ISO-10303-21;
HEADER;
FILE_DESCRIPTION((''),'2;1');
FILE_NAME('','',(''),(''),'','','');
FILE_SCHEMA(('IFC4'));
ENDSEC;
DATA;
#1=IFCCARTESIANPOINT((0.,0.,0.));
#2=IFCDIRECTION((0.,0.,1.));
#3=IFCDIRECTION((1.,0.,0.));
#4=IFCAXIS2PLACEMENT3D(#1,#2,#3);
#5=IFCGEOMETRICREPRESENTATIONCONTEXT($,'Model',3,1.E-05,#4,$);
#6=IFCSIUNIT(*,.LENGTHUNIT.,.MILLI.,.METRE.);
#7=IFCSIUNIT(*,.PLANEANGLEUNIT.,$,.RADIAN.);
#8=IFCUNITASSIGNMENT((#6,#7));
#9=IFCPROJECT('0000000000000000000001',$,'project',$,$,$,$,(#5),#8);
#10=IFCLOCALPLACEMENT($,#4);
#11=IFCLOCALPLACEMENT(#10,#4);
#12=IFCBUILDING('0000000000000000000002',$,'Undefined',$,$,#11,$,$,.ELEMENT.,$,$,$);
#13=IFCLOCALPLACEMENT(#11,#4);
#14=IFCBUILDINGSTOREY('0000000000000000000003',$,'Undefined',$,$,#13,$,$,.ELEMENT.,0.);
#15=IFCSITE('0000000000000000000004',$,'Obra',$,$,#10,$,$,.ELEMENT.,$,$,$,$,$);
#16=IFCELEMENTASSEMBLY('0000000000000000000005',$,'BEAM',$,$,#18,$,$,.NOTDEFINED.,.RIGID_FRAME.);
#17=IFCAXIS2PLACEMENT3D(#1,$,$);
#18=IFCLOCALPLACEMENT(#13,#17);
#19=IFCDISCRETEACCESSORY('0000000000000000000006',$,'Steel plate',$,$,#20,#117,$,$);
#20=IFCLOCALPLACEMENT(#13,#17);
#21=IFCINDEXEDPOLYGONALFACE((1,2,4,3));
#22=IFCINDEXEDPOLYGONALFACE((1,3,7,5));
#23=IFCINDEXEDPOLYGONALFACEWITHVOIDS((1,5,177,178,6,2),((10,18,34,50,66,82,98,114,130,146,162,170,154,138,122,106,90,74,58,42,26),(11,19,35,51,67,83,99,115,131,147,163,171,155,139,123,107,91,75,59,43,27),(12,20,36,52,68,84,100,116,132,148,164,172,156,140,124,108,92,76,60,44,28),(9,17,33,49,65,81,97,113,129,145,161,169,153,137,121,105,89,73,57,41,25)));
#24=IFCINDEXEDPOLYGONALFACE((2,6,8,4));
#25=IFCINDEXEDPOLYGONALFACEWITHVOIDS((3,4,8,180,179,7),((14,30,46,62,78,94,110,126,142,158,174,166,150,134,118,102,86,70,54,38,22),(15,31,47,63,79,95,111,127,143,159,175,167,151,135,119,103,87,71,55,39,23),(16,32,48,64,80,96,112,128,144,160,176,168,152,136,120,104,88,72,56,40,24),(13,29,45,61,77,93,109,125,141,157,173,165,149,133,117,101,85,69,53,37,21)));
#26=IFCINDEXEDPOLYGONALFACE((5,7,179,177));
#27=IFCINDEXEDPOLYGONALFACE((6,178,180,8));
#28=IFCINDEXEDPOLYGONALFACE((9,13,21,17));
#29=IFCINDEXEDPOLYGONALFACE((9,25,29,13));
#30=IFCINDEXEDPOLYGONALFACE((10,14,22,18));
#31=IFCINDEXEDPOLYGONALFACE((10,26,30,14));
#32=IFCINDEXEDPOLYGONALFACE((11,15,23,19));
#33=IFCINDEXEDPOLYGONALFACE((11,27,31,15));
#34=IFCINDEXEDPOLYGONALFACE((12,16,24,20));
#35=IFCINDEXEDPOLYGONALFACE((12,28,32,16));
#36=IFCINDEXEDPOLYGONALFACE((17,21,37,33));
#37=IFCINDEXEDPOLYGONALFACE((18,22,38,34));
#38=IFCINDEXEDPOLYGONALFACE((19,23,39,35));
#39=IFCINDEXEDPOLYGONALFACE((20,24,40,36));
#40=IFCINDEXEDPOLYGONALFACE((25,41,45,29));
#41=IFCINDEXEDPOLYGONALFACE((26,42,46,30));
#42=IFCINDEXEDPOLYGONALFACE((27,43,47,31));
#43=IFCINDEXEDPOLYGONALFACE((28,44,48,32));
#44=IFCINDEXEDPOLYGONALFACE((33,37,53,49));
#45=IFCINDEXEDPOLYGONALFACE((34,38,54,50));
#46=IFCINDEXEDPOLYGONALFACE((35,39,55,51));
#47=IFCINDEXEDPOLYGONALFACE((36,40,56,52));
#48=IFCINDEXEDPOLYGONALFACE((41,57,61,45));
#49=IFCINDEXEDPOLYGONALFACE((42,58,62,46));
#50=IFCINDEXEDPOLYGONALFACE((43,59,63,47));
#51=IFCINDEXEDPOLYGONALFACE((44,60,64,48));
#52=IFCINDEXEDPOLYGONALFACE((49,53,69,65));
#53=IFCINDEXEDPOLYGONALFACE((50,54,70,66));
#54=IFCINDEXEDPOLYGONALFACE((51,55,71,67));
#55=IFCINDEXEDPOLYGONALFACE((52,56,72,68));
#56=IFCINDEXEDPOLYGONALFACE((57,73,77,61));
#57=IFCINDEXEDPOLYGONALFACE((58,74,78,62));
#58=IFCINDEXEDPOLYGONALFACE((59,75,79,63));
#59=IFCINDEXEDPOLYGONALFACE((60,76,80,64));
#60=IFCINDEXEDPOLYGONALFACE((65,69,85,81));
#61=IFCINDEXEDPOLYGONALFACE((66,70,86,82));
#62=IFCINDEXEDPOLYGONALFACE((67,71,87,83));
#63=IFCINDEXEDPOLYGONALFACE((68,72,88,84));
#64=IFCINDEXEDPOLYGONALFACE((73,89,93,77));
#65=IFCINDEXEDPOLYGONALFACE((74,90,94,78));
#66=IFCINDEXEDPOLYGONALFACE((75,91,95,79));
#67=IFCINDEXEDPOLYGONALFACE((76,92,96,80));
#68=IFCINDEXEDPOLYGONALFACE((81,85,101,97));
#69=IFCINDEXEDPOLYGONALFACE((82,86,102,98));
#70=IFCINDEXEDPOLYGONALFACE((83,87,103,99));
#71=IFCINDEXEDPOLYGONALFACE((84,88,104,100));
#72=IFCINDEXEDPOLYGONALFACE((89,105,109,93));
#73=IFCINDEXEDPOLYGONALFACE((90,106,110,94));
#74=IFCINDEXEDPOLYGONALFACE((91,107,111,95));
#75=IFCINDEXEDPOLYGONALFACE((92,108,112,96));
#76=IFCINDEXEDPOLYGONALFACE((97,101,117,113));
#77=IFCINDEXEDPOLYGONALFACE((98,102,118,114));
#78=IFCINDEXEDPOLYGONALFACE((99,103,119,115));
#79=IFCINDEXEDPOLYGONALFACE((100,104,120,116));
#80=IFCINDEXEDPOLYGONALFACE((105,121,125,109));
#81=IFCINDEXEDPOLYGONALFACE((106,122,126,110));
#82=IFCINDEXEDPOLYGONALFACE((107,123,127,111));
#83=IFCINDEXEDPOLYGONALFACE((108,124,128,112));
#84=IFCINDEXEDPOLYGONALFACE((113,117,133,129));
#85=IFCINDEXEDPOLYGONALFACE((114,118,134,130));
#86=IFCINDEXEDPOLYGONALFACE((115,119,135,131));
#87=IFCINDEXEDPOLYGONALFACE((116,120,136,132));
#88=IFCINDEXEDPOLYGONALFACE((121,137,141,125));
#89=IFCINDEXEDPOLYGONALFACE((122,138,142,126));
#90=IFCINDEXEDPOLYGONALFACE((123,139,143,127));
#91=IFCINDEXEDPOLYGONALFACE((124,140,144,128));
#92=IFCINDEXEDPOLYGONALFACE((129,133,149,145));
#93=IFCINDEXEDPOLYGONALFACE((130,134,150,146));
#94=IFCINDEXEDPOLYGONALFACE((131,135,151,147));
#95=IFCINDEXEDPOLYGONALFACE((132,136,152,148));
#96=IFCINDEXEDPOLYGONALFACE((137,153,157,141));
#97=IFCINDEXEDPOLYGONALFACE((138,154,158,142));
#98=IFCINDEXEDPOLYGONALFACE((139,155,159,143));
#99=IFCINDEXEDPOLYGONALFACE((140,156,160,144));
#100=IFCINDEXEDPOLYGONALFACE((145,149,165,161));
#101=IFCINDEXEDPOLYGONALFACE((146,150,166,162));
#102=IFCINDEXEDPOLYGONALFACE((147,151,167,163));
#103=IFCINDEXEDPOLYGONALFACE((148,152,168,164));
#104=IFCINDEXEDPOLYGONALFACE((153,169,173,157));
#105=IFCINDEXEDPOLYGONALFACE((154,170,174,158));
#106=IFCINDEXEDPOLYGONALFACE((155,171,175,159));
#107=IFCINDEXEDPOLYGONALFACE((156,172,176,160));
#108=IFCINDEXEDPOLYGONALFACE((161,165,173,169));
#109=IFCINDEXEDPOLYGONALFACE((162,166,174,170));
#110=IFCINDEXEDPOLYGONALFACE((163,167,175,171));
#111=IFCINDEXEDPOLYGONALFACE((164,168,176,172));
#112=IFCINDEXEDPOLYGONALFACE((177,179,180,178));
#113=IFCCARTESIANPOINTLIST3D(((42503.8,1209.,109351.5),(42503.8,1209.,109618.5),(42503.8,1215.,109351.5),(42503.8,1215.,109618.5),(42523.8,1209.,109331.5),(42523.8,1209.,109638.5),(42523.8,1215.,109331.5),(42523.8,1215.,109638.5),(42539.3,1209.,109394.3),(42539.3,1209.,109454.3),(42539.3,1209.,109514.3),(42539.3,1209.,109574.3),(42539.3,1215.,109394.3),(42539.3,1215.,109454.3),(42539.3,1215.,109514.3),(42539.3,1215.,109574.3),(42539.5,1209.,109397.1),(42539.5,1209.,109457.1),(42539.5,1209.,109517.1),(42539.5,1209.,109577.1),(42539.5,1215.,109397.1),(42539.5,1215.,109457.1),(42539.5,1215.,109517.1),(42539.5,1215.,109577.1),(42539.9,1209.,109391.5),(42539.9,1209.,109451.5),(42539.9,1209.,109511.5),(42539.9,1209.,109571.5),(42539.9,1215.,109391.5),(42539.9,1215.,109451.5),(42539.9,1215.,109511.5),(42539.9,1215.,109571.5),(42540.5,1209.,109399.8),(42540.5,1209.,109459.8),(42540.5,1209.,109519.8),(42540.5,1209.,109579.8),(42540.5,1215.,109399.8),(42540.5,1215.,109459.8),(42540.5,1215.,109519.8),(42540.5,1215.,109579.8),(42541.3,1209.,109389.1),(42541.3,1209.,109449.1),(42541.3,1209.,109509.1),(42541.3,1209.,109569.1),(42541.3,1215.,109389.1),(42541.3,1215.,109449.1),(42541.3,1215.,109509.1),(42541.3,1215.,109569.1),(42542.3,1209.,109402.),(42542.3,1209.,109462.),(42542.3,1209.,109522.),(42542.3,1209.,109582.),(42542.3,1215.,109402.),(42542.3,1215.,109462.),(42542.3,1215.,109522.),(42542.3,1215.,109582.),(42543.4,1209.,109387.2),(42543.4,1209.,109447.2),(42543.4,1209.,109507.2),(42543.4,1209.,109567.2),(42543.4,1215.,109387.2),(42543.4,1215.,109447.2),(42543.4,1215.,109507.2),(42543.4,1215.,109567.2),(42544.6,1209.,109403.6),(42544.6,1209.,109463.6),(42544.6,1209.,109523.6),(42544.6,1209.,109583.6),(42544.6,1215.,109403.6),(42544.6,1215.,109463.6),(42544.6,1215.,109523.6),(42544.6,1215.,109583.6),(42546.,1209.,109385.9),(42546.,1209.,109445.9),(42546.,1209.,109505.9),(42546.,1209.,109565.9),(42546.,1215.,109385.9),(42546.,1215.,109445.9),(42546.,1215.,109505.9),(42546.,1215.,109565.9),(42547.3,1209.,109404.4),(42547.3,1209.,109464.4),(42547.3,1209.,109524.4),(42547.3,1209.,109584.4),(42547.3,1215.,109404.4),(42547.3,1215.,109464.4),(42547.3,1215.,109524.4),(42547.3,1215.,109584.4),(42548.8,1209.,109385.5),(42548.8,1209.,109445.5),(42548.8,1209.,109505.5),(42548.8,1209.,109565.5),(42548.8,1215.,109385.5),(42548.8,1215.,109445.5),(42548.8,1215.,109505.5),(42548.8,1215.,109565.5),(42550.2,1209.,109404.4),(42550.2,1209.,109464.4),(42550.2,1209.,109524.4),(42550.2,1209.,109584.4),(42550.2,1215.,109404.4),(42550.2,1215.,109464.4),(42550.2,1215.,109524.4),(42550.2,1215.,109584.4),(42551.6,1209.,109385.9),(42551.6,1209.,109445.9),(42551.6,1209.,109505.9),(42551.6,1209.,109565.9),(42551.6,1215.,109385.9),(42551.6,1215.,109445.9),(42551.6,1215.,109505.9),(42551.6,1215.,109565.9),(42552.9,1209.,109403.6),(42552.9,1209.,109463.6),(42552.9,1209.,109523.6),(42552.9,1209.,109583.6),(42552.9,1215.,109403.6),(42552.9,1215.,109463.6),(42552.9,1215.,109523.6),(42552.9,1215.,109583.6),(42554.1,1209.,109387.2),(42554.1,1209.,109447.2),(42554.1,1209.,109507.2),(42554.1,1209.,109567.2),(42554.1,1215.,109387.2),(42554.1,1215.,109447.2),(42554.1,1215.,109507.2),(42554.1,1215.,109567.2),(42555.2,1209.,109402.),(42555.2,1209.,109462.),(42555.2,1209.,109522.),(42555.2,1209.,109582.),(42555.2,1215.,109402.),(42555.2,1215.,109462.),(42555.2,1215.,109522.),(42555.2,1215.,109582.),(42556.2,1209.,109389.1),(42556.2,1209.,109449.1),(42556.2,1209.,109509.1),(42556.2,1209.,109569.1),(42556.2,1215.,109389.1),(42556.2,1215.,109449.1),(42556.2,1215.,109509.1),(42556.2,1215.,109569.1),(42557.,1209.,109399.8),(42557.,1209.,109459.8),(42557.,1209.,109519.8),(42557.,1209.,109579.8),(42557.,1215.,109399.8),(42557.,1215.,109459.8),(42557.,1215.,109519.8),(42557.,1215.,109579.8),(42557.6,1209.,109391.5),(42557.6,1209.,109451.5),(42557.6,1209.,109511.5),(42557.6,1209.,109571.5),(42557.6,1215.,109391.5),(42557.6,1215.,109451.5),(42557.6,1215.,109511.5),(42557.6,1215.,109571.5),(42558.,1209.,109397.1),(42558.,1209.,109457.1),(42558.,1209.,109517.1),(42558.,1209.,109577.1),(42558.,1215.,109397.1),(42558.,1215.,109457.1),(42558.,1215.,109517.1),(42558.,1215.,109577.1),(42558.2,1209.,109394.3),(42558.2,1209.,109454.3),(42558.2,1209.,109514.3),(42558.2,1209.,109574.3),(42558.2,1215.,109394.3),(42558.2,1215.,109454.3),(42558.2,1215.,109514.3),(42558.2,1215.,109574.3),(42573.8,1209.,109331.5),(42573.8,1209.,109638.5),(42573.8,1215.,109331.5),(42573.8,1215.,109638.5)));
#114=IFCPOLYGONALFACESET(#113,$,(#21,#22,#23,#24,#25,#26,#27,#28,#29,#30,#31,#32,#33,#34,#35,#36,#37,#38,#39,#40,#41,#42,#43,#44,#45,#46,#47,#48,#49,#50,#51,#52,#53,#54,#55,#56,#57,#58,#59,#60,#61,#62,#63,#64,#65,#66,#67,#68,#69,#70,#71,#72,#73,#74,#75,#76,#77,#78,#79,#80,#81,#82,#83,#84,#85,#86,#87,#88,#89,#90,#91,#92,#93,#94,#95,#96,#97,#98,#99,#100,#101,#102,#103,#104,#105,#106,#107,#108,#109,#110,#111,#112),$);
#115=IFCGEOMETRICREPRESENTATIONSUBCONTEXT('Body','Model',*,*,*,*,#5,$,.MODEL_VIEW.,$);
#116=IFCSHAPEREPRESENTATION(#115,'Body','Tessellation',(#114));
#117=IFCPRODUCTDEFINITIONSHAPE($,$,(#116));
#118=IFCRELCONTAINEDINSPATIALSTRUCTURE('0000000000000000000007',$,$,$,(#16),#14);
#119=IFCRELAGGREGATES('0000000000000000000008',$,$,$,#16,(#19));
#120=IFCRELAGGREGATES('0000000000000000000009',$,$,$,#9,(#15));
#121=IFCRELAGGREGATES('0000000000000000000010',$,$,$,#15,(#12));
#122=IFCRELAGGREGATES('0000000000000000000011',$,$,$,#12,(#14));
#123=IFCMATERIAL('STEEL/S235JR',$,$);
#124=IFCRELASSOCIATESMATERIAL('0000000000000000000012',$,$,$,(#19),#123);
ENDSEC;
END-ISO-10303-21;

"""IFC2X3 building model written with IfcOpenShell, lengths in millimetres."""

from ifc_helpers import new_model, si_unit, frame, origin_with_axes, origin_2d_with_axis, place, context, subcontext, project, spatial, polyline, circle, outline, extrude, source, transform, mapped, material, element, aggregate, save


model = new_model("IFC2X3")

# Units and contexts
model_context = context("Model", 3, precision=1e-05, world=origin_with_axes())
body_context = subcontext(model_context, "Body", "Model", "MODEL_VIEW")
ifc_project = project(units=[si_unit("LENGTHUNIT", "METRE", prefix="MILLI"), si_unit("PLANEANGLEUNIT", "RADIAN")], contexts=[model_context])

# Site, building, storey
site_placement = place(None, origin_with_axes())
site = spatial("IfcSite", under=ifc_project, at=site_placement, Name="Obra", CompositionType="ELEMENT")
building_placement = place(site_placement, origin_with_axes())
building = spatial("IfcBuilding", under=site, at=building_placement, Name="Undefined", CompositionType="ELEMENT")
storey_placement = place(building_placement, origin_with_axes())
storey = spatial("IfcBuildingStorey", under=building, at=storey_placement, Name="Undefined", CompositionType="ELEMENT", Elevation=0.0)

# Element assembly, discrete accessory, opening
ifc_material = material(Name="STEEL/S235JR")
shared_shape = source(origin_with_axes(), body_context, "Body", "SweptSolid", [
    extrude(circle(Radius=9.5, at=origin_2d_with_axis()), frame((0.0, -9.8, 0.0), z_axis=(0.0, 1.0, 0.0), x_axis=(1.0, 0.0, 0.0)), (0.0, 0.0, 1.0), 6.2),
])
assembly_1_placement = place(storey_placement, origin_with_axes())
assembly_1 = element("IfcElementAssembly", 1, at=assembly_1_placement, inside=storey, Name="BEAM", AssemblyPlace="NOTDEFINED", PredefinedType="RIGID_FRAME")
discrete_accessory_1_placement = place(assembly_1_placement, frame((42573.8, 1212.0, 109331.5), z_axis=(0.0, 1.0, 0.0), x_axis=(-1.0, 0.0, 0.0)))
discrete_accessory_1 = element("IfcDiscreteAccessory", 2, at=discrete_accessory_1_placement, material=ifc_material, Name="Steel plate", context=body_context, shape_type="SweptSolid", body=[
    extrude(outline(polyline([(0.0, 0.0), (50.0, 0.0), (70.0, 20.0), (70.0, 287.0), (50.0, 307.0), (0.0, 307.0), (0.0, 0.0)])), frame((0.0, 0.0, -3.0), z_axis=(0.0, 0.0, 1.0), x_axis=(1.0, 0.0, 0.0)), (0.0, 0.0, 1.0), 6.0),
])
opening_1_placement = place(assembly_1_placement, frame((42513.8, 1218.8, 109650.0), z_axis=(1.0, 0.0, 0.0), x_axis=(0.0, 0.0, -1.0)))
element("IfcOpeningElement", 3, at=opening_1_placement, cuts=discrete_accessory_1, ObjectType="Opening", context=body_context, shape_type="MappedRepresentation", body=[
    mapped(shared_shape, transform((75.0, 0.0, 35.0))),
    mapped(shared_shape, transform((135.0, 0.0, 35.0))),
    mapped(shared_shape, transform((195.0, 0.0, 35.0))),
    mapped(shared_shape, transform((255.0, 0.0, 35.0))),
])
aggregate(assembly_1, [discrete_accessory_1])

save(model, "model.ifc")
